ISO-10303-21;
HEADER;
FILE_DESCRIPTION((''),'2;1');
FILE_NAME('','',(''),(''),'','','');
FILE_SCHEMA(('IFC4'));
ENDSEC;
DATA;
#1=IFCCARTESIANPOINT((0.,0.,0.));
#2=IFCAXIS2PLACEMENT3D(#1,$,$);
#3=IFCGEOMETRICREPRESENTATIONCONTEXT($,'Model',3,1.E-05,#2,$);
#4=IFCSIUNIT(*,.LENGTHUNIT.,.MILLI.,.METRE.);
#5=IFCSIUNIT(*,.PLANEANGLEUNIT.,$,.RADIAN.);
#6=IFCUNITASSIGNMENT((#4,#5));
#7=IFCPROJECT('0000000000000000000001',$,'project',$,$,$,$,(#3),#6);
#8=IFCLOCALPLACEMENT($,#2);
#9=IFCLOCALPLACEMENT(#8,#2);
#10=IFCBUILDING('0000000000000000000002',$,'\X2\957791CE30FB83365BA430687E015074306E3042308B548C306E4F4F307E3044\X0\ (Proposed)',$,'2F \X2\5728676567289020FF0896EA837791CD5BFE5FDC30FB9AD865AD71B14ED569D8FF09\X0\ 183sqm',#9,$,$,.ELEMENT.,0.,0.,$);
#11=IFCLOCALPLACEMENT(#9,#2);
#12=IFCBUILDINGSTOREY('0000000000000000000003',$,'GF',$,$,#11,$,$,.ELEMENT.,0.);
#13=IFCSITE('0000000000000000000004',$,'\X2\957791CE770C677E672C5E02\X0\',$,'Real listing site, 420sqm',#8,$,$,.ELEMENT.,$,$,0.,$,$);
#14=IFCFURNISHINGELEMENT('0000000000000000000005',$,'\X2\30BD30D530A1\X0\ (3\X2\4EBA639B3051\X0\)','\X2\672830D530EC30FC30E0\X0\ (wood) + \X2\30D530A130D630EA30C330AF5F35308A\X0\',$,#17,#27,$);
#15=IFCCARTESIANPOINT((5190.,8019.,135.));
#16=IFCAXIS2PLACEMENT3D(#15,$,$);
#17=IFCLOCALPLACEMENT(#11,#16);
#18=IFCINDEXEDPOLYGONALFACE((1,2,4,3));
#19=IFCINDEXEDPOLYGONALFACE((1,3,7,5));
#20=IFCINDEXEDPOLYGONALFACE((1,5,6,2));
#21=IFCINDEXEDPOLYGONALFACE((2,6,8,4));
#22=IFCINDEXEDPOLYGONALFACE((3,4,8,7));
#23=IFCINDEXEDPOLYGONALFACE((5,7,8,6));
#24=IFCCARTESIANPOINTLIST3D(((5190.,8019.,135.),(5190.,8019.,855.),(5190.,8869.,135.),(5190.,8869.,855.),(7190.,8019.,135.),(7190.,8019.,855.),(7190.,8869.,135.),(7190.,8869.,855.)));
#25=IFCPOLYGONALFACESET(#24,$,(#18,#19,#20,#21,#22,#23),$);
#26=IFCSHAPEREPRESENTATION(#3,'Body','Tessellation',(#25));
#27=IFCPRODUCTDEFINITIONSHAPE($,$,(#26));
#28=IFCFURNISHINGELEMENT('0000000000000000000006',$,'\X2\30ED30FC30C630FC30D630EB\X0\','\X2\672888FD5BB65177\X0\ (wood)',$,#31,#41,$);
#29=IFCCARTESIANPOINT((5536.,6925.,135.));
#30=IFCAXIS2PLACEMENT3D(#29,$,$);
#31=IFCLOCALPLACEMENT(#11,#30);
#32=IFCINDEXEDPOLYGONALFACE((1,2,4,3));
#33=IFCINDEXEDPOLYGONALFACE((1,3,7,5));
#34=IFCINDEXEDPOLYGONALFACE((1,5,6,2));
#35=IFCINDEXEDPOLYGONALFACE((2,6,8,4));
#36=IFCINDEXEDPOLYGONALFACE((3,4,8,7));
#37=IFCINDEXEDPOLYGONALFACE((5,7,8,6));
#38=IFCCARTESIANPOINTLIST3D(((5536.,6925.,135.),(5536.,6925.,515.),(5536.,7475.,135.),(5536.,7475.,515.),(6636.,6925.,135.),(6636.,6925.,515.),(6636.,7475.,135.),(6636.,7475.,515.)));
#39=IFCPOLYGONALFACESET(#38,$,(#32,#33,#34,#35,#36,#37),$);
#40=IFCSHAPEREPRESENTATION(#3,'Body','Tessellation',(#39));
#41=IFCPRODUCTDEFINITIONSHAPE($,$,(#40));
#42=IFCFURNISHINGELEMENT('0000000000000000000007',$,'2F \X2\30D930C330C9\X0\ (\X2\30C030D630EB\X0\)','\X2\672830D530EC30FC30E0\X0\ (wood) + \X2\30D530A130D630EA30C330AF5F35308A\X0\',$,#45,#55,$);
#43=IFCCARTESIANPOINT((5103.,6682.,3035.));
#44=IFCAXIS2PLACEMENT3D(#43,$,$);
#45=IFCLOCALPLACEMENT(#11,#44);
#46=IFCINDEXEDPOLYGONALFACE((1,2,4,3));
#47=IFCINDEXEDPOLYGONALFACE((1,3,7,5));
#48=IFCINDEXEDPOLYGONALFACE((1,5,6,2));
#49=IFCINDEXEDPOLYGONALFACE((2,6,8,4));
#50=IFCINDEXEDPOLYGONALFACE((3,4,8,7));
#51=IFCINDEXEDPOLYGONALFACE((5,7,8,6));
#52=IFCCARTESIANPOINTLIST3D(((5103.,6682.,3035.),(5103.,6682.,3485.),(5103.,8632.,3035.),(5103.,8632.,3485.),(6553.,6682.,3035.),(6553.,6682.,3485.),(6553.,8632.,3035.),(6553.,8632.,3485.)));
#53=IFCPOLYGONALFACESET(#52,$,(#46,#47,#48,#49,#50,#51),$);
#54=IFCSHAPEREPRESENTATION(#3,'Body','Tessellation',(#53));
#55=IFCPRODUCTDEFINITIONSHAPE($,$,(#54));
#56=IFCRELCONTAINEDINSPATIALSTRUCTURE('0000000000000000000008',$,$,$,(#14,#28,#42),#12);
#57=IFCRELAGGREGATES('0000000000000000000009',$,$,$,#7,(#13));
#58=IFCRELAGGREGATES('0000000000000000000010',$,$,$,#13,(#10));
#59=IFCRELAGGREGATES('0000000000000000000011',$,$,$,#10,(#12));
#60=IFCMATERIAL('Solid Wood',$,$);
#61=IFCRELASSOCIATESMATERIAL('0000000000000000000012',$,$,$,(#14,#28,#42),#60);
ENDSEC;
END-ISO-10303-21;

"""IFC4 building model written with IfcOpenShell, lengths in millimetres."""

from ifc_helpers import new_model, si_unit, frame, frame_2d, origin, place, context, project, spatial, rectangle, extrude, material, element, save


model = new_model("IFC4")

# Units and contexts
model_context = context("Model", 3, precision=1e-05, world=origin())
ifc_project = project(units=[si_unit("LENGTHUNIT", "METRE", prefix="MILLI"), si_unit("PLANEANGLEUNIT", "RADIAN")], contexts=[model_context])

# Site, building, storey
site_placement = place(None, origin())
site = spatial("IfcSite", under=ifc_project, at=site_placement, Name="長野県松本市", ObjectType="Real listing site, 420sqm", CompositionType="ELEMENT", RefElevation=0.0)
building_placement = place(site_placement, origin())
building = spatial("IfcBuilding", under=site, at=building_placement, Name="長野・茶室と縁側のある和の住まい (Proposed)", ObjectType="2F 在来木造（雪荷重対応・高断熱仕様） 183sqm", CompositionType="ELEMENT", ElevationOfRefHeight=0.0, ElevationOfTerrain=0.0)
storey_placement = place(building_placement, origin())
storey = spatial("IfcBuildingStorey", under=building, at=storey_placement, Name="GF", CompositionType="ELEMENT", Elevation=0.0)

# Shared definitions
ifc_material_1 = material(Name="Solid Wood")

# Furnishing elements
furnishing_1_placement = place(storey_placement, frame((5190.0, 8019.0, 135.0)))
element("IfcFurnishingElement", 1, at=furnishing_1_placement, inside=storey, material=ifc_material_1, Name="ソファ (3人掛け)", Description="木フレーム (wood) + ファブリック張り", context=model_context, shape_type="SweptSolid", body=[
    extrude(rectangle(XDim=2000.0, YDim=850.0, at=frame_2d((1000.0, 425.0))), frame((5190.0, 8019.0, 135.0)), (0.0, 0.0, 1.0), 720.0),
])
furnishing_2_placement = place(storey_placement, frame((5536.0, 6925.0, 135.0)))
element("IfcFurnishingElement", 2, at=furnishing_2_placement, inside=storey, material=ifc_material_1, Name="ローテーブル", Description="木製家具 (wood)", context=model_context, shape_type="SweptSolid", body=[
    extrude(rectangle(XDim=1100.0, YDim=550.0, at=frame_2d((550.0, 275.0))), frame((5536.0, 6925.0, 135.0)), (0.0, 0.0, 1.0), 380.0),
])
furnishing_3_placement = place(storey_placement, frame((5103.0, 6682.0, 3035.0)))
element("IfcFurnishingElement", 3, at=furnishing_3_placement, inside=storey, material=ifc_material_1, Name="2F ベッド (ダブル)", Description="木フレーム (wood) + ファブリック張り", context=model_context, shape_type="SweptSolid", body=[
    extrude(rectangle(XDim=1450.0, YDim=1950.0, at=frame_2d((725.0, 975.0))), frame((5103.0, 6682.0, 3035.0)), (0.0, 0.0, 1.0), 450.0),
])

save(model, "model.ifc")
